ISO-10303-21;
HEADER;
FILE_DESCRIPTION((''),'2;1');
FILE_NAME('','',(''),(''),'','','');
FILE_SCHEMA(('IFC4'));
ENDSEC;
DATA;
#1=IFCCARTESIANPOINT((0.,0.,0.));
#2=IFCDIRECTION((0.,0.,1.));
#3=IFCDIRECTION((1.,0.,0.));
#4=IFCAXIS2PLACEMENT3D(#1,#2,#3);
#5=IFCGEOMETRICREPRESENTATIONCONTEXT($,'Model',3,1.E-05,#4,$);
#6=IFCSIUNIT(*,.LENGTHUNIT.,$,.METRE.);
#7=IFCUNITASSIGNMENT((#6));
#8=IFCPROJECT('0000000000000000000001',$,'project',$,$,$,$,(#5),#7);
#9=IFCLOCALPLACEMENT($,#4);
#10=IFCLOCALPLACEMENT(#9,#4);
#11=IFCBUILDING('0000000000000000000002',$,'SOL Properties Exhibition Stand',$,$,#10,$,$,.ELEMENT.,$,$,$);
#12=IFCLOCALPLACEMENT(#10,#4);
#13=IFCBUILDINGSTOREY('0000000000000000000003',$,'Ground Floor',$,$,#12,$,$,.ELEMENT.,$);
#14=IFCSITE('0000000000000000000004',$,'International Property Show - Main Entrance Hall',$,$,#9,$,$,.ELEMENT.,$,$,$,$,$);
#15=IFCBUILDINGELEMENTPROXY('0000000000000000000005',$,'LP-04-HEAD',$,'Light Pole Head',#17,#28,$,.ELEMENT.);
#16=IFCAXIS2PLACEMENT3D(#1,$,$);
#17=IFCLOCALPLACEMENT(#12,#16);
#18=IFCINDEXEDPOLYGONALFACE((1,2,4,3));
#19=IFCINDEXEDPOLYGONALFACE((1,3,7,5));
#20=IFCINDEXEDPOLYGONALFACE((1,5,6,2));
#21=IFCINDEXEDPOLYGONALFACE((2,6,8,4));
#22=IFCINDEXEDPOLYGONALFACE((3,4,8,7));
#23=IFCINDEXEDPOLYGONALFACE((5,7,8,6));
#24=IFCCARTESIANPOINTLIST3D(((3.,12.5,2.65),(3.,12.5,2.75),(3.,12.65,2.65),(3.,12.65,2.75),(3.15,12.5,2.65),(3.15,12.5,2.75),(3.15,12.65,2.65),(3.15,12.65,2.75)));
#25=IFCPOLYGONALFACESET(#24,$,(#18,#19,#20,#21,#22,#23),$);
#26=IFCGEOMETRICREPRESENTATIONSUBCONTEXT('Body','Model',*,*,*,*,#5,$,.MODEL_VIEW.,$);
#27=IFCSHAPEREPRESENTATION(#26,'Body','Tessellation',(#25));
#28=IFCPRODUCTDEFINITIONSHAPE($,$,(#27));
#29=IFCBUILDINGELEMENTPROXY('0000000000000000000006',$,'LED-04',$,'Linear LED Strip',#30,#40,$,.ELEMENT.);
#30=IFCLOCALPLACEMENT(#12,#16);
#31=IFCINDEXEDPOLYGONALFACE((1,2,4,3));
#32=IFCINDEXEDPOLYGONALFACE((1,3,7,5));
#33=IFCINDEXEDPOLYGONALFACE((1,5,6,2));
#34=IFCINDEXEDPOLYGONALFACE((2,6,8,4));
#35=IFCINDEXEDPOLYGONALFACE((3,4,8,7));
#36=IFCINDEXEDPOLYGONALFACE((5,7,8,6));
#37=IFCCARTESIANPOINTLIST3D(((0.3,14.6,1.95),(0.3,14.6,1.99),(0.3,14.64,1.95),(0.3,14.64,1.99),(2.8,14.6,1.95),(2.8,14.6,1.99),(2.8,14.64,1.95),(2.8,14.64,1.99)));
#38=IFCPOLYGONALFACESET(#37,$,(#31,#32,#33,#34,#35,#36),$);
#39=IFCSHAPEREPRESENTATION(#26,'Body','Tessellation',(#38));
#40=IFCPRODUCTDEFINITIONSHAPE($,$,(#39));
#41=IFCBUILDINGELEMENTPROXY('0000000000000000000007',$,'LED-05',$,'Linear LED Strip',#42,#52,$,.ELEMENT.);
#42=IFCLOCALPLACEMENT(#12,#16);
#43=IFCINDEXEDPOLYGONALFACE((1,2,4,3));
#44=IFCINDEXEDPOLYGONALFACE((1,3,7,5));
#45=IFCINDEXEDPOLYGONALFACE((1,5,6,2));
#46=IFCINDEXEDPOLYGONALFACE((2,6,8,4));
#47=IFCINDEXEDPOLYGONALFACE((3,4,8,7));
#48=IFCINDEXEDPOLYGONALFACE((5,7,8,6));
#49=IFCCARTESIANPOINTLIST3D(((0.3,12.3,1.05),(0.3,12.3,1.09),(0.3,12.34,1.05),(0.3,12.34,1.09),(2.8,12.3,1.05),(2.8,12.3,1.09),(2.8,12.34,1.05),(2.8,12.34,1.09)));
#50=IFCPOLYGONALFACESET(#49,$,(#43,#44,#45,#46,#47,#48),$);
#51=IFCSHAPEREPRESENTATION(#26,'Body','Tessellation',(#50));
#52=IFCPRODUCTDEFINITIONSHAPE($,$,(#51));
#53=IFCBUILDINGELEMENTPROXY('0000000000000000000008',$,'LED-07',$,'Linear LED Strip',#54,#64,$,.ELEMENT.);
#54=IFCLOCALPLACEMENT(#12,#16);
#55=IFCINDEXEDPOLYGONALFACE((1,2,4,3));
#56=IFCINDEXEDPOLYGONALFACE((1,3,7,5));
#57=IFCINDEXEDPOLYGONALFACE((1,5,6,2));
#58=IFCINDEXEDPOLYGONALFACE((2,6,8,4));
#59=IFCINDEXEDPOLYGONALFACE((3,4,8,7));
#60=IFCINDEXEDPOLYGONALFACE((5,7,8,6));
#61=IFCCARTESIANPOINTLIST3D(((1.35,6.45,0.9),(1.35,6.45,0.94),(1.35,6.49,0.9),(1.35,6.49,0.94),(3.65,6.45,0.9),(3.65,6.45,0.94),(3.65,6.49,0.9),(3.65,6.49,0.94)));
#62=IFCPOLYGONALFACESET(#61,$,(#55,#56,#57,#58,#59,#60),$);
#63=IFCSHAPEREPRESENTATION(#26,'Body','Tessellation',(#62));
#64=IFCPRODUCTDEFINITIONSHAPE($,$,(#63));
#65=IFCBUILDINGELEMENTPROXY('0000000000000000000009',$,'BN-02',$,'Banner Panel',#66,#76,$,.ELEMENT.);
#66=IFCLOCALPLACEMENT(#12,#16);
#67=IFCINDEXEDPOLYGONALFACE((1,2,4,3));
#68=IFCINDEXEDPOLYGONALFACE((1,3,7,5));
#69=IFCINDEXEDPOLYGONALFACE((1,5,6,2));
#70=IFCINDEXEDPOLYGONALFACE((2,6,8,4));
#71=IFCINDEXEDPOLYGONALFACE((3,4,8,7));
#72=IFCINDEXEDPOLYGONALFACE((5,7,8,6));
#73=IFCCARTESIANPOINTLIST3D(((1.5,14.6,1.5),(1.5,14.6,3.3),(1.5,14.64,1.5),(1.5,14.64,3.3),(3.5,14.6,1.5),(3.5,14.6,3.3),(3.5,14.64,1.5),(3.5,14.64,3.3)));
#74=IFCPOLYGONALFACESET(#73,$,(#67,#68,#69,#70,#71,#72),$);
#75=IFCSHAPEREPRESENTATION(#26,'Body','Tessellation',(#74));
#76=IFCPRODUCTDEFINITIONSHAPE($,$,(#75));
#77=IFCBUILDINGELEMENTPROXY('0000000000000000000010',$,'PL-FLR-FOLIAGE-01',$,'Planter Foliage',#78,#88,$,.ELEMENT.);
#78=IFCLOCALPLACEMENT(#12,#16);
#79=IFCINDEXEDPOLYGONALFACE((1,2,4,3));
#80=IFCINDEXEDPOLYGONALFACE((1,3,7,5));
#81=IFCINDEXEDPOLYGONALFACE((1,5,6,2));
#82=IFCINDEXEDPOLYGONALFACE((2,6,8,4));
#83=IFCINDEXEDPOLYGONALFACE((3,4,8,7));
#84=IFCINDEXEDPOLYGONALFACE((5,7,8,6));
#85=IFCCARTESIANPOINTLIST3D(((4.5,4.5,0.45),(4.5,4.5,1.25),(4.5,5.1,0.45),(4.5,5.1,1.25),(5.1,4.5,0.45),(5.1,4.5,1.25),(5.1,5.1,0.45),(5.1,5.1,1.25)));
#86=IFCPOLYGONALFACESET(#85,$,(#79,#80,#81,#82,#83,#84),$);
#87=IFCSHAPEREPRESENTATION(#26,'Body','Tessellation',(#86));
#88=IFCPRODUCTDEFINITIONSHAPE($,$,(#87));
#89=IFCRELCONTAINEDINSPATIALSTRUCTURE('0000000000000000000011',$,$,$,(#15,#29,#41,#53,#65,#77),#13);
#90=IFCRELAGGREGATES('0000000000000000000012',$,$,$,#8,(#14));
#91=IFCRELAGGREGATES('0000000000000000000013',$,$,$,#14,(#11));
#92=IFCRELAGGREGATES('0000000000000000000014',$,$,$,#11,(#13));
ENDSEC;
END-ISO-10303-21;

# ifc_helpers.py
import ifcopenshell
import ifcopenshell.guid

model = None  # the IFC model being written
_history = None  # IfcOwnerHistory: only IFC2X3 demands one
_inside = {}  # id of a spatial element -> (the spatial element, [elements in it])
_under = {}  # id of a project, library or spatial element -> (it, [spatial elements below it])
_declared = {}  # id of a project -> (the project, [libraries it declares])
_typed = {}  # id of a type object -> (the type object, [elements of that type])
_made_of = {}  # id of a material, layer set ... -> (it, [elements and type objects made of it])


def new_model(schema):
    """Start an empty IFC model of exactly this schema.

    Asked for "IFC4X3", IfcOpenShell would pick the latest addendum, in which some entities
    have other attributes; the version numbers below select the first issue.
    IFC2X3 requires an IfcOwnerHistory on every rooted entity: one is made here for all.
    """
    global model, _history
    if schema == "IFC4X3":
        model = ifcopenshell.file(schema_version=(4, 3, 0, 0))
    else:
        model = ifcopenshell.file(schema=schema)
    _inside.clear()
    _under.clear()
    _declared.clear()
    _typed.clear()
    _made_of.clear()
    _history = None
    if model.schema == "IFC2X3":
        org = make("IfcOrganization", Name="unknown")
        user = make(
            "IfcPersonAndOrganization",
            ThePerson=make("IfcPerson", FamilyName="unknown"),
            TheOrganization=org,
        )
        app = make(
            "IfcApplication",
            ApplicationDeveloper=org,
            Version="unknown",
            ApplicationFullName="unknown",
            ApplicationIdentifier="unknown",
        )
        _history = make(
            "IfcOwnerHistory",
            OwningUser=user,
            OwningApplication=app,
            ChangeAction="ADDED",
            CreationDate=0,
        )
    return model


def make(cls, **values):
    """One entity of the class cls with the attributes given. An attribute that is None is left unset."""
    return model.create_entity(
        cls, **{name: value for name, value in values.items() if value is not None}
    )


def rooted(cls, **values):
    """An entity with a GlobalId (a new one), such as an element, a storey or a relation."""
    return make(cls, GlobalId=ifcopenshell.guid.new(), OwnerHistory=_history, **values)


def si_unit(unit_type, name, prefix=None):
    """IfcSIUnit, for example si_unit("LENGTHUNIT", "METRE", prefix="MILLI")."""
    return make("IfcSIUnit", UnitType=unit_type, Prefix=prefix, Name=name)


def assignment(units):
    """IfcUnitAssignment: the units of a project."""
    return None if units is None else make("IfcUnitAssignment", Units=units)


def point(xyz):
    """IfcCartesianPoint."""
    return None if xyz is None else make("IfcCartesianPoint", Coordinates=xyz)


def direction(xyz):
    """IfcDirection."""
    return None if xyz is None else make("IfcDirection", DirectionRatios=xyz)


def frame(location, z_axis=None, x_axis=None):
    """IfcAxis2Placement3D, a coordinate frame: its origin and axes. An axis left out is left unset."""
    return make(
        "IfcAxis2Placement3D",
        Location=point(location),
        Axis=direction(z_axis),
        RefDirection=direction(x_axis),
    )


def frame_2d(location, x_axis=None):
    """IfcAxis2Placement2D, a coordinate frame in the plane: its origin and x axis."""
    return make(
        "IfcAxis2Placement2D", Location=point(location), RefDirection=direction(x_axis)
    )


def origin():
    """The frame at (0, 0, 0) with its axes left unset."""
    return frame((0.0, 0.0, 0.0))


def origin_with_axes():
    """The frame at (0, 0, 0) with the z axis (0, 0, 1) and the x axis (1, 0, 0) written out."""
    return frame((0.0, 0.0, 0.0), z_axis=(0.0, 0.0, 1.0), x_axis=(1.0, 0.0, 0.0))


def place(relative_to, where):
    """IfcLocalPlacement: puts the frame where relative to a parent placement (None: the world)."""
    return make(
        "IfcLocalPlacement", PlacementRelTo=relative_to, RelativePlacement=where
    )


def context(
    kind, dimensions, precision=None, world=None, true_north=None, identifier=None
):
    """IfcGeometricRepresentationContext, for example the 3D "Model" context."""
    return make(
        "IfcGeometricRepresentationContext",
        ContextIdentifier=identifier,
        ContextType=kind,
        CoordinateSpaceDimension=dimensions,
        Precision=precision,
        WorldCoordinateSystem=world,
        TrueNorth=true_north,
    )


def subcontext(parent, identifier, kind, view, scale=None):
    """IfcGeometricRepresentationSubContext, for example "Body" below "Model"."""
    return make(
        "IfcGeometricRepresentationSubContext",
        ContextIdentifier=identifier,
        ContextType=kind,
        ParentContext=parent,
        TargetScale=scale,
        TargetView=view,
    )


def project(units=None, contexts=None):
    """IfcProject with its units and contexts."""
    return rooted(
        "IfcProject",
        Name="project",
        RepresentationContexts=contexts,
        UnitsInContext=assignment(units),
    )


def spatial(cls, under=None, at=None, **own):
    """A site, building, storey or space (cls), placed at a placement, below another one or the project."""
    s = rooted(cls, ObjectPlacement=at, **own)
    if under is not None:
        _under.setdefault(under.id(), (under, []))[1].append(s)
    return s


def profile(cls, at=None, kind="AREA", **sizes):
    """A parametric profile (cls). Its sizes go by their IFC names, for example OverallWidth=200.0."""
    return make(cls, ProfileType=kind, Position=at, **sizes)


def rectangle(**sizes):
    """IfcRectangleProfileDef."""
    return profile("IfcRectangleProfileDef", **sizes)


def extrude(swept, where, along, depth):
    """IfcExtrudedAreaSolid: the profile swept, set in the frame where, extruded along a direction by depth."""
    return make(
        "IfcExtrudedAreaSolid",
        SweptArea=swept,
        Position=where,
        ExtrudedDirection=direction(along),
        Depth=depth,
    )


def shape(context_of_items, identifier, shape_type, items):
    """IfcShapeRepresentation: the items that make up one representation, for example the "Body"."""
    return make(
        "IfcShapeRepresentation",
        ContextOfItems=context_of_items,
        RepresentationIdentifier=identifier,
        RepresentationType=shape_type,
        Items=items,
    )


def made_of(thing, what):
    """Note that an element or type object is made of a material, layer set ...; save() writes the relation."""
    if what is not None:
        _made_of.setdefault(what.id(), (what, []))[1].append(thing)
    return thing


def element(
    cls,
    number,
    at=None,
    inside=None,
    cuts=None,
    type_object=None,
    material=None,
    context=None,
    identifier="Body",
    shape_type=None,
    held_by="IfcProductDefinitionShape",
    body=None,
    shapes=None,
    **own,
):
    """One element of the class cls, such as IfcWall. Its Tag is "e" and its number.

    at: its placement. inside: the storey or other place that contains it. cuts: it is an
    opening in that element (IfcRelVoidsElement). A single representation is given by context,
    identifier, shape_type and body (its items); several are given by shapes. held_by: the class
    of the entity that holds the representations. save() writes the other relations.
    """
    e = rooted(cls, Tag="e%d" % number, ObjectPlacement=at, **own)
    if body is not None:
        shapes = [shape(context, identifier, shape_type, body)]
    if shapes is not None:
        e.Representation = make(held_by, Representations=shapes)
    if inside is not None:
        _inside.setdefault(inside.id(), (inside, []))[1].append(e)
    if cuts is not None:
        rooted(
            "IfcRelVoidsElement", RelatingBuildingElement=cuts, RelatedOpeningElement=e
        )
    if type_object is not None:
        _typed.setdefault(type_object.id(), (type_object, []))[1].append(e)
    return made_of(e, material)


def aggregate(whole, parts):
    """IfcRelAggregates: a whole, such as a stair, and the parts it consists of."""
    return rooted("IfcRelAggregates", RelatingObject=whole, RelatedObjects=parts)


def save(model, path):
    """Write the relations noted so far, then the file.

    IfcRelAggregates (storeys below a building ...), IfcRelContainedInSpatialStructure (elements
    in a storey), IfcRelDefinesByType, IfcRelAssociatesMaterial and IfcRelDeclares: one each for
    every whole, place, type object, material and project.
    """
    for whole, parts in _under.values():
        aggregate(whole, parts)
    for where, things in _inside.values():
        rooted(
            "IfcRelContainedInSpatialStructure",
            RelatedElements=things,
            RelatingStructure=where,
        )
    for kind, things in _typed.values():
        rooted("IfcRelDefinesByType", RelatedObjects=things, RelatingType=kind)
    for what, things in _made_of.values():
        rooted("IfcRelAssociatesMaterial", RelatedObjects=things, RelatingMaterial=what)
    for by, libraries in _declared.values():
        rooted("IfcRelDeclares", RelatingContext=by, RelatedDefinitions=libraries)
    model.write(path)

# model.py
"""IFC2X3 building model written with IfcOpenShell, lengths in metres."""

from ifc_helpers import new_model, si_unit, frame, frame_2d, origin, origin_with_axes, place, context, subcontext, project, spatial, rectangle, extrude, element, save


model = new_model("IFC2X3")

# Units and contexts
model_context = context("Model", 3, precision=1e-05, world=origin_with_axes())
body_context = subcontext(model_context, "Body", "Model", "MODEL_VIEW")
ifc_project = project(units=[si_unit("LENGTHUNIT", "METRE")], contexts=[model_context])

# Site, building, storey
site_placement = place(None, origin_with_axes())
site = spatial("IfcSite", under=ifc_project, at=site_placement, Name="International Property Show - Main Entrance Hall", CompositionType="ELEMENT")
building_placement = place(site_placement, origin_with_axes())
building = spatial("IfcBuilding", under=site, at=building_placement, Name="SOL Properties Exhibition Stand", CompositionType="ELEMENT")
storey_placement = place(building_placement, origin_with_axes())
storey = spatial("IfcBuildingStorey", under=building, at=storey_placement, Name="Ground Floor", CompositionType="ELEMENT")

# Building element proxies
for number, where, z_axis, x_axis, name in (
    (1, (3.0, 12.5, 2.65), (0.0, 0.0, 1.0), (1.0, 0.0, 0.0), "LP-04-HEAD"),
):
    element("IfcBuildingElementProxy", number, at=place(storey_placement, frame(where, z_axis=z_axis, x_axis=x_axis)), inside=storey, Name=name, ObjectType="Light Pole Head", CompositionType="ELEMENT", context=body_context, shape_type="SweptSolid", body=[
        extrude(rectangle(XDim=0.15, YDim=0.15, at=frame_2d((0.075, 0.075))), origin(), (0.0, 0.0, 1.0), 0.1),
    ])
for number, where, z_axis, x_axis, name in (
    (2, (0.3, 14.6, 1.95), (0.0, 0.0, 1.0), (1.0, 0.0, 0.0), "LED-04"),
    (3, (0.3, 12.3, 1.05), (0.0, 0.0, 1.0), (1.0, 0.0, 0.0), "LED-05"),
):
    element("IfcBuildingElementProxy", number, at=place(storey_placement, frame(where, z_axis=z_axis, x_axis=x_axis)), inside=storey, Name=name, ObjectType="Linear LED Strip", CompositionType="ELEMENT", context=body_context, shape_type="SweptSolid", body=[
        extrude(rectangle(XDim=2.5, YDim=0.04, at=frame_2d((1.25, 0.02))), origin(), (0.0, 0.0, 1.0), 0.04),
    ])
proxy_1_placement = place(storey_placement, frame((1.35, 6.45, 0.9), z_axis=(0.0, 0.0, 1.0), x_axis=(1.0, 0.0, 0.0)))
element("IfcBuildingElementProxy", 4, at=proxy_1_placement, inside=storey, Name="LED-07", ObjectType="Linear LED Strip", CompositionType="ELEMENT", context=body_context, shape_type="SweptSolid", body=[
    extrude(rectangle(XDim=2.3, YDim=0.04, at=frame_2d((1.15, 0.02))), origin(), (0.0, 0.0, 1.0), 0.04),
])
proxy_2_placement = place(storey_placement, frame((1.5, 14.6, 1.5), z_axis=(0.0, 0.0, 1.0), x_axis=(1.0, 0.0, 0.0)))
element("IfcBuildingElementProxy", 5, at=proxy_2_placement, inside=storey, Name="BN-02", ObjectType="Banner Panel", CompositionType="ELEMENT", context=body_context, shape_type="SweptSolid", body=[
    extrude(rectangle(XDim=2.0, YDim=0.04, at=frame_2d((1.0, 0.02))), origin(), (0.0, 0.0, 1.0), 1.8),
])
proxy_3_placement = place(storey_placement, frame((4.5, 4.5, 0.45), z_axis=(0.0, 0.0, 1.0), x_axis=(1.0, 0.0, 0.0)))
element("IfcBuildingElementProxy", 6, at=proxy_3_placement, inside=storey, Name="PL-FLR-FOLIAGE-01", ObjectType="Planter Foliage", CompositionType="ELEMENT", context=body_context, shape_type="SweptSolid", body=[
    extrude(rectangle(XDim=0.6, YDim=0.6, at=frame_2d((0.3, 0.3))), origin(), (0.0, 0.0, 1.0), 0.8),
])

save(model, "model.ifc")
